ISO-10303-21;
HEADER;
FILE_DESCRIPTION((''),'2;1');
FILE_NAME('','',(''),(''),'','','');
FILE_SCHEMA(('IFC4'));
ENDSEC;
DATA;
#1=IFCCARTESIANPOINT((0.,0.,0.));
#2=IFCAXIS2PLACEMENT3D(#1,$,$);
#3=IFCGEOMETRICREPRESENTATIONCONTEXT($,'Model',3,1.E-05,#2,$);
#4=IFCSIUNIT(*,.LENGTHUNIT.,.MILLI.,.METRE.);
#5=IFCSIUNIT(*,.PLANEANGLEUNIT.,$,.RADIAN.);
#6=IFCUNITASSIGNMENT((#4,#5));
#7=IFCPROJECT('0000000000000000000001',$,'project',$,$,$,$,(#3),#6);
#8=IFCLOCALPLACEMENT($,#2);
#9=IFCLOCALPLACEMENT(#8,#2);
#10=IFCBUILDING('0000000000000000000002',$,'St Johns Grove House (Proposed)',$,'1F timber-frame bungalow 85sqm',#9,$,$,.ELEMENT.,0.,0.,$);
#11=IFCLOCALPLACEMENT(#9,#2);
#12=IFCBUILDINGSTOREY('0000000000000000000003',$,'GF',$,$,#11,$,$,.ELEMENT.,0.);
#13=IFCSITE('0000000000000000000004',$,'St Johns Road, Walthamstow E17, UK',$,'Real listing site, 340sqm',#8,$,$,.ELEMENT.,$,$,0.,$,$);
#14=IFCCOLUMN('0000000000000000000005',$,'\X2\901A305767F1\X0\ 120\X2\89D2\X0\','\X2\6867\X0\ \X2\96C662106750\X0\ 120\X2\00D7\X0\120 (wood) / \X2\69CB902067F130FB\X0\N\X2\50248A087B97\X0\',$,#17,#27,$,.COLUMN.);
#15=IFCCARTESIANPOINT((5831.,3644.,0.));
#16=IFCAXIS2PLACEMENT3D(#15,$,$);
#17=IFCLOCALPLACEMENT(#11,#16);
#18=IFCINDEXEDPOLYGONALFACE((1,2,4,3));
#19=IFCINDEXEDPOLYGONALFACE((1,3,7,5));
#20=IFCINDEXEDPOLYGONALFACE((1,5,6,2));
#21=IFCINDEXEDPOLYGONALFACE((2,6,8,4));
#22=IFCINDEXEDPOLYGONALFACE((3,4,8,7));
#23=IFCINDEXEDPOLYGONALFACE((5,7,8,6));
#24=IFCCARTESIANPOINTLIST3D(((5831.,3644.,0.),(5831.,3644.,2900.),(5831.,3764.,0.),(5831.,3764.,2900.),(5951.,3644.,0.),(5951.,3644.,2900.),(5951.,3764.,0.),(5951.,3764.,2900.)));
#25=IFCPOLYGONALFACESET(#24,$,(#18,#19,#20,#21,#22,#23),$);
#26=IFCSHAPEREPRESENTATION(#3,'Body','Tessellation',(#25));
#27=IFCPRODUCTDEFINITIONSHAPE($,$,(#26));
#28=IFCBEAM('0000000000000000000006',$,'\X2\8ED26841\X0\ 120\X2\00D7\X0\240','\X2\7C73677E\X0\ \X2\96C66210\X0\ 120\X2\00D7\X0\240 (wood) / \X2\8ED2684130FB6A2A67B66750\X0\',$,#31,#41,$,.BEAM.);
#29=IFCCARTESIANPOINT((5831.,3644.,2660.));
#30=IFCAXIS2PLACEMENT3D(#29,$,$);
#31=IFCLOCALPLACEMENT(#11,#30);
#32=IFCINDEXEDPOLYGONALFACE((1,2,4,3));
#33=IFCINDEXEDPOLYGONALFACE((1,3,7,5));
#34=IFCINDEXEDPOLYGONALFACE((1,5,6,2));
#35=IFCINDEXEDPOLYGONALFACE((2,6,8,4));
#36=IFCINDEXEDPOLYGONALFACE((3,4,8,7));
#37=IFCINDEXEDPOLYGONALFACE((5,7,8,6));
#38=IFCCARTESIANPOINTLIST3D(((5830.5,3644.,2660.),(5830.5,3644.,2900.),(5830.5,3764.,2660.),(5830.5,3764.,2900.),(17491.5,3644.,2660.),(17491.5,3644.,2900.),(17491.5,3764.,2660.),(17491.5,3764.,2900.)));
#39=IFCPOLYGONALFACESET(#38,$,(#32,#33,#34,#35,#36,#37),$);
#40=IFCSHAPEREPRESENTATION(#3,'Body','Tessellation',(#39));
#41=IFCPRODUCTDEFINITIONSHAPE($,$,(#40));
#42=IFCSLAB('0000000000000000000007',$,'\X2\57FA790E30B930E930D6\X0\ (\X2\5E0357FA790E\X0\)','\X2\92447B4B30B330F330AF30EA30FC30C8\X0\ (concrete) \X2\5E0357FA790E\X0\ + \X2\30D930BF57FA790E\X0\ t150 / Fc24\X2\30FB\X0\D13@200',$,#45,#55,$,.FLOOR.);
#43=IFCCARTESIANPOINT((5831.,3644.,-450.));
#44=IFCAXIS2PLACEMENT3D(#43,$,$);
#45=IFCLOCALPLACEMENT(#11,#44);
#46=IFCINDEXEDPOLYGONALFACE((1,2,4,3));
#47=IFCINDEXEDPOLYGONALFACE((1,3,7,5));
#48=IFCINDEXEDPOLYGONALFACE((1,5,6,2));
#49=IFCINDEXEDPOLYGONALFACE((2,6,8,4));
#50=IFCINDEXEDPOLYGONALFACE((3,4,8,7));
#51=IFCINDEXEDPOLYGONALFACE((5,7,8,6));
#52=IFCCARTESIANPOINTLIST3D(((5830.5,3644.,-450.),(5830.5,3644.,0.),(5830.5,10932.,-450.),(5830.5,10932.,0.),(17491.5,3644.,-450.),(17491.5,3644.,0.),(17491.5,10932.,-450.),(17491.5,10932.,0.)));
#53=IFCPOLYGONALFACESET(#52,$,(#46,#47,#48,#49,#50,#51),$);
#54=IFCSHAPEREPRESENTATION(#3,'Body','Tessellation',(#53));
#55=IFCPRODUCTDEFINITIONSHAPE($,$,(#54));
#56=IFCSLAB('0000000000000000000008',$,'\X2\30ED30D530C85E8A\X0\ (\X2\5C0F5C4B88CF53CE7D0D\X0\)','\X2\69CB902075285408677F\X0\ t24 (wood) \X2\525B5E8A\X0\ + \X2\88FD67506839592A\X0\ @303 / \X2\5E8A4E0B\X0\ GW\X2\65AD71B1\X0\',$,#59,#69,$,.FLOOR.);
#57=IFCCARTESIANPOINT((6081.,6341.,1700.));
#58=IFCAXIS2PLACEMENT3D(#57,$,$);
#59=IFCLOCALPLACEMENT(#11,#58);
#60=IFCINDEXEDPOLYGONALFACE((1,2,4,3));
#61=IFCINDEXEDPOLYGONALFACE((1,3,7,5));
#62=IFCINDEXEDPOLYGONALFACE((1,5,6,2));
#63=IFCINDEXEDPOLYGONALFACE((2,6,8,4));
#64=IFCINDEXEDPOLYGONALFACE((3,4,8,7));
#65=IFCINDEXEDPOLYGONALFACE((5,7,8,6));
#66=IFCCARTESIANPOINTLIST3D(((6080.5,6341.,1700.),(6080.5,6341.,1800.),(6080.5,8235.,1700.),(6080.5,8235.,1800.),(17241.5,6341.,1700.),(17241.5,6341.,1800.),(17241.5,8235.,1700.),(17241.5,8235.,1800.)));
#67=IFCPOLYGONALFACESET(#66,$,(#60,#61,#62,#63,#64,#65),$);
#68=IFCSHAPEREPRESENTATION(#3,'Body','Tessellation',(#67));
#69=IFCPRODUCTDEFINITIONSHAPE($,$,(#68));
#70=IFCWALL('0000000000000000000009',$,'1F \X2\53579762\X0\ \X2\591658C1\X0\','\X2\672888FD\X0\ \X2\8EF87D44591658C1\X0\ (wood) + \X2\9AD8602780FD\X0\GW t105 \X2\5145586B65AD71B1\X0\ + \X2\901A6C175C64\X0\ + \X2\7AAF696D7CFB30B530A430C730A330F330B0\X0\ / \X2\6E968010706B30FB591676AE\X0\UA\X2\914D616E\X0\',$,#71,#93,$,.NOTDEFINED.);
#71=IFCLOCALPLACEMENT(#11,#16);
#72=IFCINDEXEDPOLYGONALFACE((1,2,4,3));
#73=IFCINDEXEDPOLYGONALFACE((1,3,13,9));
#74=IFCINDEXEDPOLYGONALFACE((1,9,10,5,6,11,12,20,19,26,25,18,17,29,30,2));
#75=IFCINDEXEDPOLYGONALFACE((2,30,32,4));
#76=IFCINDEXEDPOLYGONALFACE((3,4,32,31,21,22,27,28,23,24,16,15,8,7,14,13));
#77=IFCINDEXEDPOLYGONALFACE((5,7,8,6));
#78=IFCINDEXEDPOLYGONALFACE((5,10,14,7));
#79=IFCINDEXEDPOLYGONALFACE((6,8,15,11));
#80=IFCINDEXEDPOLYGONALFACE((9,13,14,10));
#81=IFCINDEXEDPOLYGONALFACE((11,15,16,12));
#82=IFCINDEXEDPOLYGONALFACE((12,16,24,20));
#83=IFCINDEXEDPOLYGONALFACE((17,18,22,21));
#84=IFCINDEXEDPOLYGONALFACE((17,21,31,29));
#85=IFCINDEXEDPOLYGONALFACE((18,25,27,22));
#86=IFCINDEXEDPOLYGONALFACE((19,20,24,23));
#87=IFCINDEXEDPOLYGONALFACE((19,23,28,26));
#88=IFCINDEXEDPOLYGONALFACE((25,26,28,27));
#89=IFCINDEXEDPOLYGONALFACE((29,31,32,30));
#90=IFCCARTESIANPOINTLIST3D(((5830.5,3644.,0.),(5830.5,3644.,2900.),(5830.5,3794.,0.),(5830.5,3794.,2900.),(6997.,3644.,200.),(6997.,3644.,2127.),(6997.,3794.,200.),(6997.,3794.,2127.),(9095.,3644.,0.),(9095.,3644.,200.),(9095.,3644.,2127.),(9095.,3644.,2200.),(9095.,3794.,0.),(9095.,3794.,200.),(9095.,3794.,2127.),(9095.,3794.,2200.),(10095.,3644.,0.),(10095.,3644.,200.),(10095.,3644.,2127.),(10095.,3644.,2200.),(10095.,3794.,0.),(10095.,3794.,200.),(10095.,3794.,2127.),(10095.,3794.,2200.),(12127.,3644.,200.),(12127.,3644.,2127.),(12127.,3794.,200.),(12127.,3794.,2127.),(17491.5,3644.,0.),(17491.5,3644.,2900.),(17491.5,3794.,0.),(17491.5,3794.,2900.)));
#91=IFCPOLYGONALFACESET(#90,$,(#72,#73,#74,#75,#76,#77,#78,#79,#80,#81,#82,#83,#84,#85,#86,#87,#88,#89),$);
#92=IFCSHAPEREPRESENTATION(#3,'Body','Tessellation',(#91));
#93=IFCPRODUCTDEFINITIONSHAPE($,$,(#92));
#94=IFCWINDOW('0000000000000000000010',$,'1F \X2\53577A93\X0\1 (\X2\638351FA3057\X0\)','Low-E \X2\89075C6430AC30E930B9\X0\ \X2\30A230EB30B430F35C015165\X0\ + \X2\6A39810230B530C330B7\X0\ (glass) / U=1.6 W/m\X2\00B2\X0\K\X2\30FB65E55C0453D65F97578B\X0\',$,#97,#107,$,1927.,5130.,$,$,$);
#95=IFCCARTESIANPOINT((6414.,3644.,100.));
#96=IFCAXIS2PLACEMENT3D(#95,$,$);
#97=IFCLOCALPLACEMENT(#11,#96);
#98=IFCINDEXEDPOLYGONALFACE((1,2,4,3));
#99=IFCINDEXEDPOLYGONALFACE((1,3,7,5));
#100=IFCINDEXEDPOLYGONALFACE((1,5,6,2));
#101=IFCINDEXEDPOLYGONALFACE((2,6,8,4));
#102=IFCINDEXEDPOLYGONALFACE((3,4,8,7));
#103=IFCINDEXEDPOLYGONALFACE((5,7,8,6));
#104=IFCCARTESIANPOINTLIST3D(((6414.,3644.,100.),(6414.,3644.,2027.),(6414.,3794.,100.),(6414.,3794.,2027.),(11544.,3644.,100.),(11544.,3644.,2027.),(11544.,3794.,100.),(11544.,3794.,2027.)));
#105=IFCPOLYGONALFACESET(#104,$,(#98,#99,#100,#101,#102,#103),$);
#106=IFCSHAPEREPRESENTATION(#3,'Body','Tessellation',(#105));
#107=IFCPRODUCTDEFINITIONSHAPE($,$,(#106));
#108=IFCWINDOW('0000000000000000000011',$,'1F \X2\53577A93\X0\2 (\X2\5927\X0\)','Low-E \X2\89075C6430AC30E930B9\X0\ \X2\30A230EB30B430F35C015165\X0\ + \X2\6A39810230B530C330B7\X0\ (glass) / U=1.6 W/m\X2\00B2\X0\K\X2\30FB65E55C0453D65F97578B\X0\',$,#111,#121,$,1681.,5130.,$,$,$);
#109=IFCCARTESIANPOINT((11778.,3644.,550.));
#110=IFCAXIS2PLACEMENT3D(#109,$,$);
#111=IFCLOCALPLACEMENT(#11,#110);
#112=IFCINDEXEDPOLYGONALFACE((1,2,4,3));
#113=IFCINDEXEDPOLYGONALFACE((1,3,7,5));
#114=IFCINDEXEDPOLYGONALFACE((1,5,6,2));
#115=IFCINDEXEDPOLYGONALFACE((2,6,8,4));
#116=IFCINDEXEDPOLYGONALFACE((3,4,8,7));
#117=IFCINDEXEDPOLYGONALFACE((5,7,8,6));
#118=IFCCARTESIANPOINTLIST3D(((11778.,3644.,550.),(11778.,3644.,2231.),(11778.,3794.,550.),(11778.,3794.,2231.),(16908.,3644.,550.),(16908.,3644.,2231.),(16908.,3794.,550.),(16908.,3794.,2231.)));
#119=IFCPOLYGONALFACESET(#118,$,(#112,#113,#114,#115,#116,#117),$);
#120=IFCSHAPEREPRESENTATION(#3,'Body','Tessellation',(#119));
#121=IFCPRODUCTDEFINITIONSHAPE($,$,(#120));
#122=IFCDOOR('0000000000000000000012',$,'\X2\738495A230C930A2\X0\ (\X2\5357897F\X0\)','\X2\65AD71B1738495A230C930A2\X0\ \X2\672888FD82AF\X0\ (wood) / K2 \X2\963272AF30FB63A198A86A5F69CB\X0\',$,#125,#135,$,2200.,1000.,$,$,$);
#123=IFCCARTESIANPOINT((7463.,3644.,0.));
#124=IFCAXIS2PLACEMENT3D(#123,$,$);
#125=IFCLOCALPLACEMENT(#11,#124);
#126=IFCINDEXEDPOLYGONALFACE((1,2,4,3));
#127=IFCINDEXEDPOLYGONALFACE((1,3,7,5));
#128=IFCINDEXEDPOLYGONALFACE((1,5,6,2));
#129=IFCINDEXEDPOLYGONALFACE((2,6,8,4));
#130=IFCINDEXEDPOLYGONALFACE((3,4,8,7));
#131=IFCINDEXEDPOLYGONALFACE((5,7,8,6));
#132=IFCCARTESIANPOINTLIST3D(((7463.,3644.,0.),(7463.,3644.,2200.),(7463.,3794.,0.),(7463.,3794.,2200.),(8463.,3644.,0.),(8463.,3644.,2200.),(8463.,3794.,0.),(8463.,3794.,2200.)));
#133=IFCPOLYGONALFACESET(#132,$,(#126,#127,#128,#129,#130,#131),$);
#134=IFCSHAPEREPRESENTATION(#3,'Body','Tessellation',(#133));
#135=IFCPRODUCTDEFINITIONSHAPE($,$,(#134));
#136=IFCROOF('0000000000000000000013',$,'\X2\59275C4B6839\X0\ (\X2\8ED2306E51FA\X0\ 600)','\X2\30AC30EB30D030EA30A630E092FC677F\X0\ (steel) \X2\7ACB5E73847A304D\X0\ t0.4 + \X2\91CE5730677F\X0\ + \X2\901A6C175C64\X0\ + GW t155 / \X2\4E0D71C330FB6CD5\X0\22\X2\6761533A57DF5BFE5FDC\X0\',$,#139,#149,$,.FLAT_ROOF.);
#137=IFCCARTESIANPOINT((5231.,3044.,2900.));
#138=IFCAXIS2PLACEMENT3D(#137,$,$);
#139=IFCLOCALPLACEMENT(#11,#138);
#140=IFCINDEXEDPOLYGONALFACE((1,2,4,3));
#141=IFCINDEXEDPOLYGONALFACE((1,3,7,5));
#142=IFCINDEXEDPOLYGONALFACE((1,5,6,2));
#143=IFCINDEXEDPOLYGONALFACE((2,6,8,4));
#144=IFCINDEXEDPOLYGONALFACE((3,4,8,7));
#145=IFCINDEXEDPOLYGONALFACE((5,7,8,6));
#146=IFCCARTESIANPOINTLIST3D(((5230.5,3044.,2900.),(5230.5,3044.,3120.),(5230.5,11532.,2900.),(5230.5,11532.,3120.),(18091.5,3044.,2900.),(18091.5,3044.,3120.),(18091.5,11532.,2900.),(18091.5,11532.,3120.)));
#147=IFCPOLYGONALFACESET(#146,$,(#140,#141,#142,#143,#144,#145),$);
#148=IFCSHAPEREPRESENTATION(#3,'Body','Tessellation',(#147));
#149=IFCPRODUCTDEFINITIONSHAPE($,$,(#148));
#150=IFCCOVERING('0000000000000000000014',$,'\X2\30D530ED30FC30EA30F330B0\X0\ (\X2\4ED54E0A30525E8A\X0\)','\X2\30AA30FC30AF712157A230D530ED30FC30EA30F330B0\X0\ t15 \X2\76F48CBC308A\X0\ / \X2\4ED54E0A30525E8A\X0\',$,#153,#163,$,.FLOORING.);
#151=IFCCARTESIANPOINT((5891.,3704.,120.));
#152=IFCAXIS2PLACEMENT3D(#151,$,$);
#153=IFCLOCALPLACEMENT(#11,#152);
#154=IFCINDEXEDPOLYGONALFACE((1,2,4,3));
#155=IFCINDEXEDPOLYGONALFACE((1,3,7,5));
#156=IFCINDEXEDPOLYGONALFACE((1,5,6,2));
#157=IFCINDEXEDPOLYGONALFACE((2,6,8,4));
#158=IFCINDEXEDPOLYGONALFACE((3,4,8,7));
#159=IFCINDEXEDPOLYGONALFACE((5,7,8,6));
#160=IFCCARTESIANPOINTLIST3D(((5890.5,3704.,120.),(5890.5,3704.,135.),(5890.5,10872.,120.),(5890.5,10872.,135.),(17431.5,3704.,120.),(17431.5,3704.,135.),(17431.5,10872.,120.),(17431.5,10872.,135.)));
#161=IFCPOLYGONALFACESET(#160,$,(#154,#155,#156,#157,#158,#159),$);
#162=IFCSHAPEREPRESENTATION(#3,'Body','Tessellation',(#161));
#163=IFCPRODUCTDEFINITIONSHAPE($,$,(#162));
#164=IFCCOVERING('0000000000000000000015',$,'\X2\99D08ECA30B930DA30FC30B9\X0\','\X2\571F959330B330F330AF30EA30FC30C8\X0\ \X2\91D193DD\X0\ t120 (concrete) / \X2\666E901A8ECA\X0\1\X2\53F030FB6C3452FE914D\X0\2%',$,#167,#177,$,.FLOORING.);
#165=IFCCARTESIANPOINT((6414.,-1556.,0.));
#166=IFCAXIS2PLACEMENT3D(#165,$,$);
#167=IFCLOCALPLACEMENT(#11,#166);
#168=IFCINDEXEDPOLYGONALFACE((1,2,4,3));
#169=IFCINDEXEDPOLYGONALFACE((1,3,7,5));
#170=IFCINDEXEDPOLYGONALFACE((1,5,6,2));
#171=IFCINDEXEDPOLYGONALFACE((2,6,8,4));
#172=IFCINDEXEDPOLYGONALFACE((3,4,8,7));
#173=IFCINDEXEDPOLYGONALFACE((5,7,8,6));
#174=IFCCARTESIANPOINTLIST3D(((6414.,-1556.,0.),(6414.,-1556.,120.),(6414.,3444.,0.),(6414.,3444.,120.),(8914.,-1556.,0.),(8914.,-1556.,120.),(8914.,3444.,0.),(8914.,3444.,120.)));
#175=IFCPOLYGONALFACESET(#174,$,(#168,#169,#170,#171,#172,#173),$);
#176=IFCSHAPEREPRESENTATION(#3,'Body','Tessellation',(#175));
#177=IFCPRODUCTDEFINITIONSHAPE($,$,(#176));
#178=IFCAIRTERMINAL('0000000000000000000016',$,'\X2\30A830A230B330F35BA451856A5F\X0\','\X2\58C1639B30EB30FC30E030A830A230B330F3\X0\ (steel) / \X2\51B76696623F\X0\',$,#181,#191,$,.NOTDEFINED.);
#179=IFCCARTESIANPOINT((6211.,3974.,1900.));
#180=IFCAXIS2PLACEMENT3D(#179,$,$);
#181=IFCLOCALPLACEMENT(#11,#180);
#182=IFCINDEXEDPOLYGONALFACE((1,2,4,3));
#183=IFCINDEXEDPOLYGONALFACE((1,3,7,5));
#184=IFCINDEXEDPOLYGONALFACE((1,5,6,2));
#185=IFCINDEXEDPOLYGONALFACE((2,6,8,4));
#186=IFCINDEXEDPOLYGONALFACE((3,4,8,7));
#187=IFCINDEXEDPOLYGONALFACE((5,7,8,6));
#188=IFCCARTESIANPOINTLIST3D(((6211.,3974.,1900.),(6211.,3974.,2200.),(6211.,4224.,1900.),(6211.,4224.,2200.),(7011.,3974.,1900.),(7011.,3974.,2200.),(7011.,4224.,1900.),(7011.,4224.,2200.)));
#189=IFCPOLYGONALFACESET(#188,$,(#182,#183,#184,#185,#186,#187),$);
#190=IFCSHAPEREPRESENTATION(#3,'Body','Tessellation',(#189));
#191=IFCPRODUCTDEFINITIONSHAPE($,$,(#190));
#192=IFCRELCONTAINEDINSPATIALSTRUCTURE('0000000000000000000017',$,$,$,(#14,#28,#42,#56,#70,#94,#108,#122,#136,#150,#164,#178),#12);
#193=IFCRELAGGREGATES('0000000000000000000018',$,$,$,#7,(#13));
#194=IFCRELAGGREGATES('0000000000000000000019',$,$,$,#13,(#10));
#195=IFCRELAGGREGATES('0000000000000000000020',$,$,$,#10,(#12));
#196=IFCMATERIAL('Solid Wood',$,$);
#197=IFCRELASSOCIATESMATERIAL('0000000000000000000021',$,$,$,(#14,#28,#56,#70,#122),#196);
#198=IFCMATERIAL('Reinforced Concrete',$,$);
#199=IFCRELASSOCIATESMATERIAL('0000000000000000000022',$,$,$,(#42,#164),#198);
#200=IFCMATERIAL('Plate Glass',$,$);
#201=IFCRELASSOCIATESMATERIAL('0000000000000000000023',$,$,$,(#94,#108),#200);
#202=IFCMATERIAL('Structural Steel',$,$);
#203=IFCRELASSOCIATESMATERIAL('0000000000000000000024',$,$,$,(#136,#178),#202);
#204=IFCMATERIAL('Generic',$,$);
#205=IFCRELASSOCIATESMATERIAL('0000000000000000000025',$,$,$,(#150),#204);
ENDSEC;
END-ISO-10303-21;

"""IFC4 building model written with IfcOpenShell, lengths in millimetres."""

from ifc_helpers import new_model, si_unit, frame, frame_2d, origin, place, context, project, spatial, rectangle, extrude, material, element, fill, save


model = new_model("IFC4")

# Units and contexts
model_context = context("Model", 3, precision=1e-05, world=origin())
ifc_project = project(units=[si_unit("LENGTHUNIT", "METRE", prefix="MILLI"), si_unit("PLANEANGLEUNIT", "RADIAN")], contexts=[model_context])

# Site, building, storey
site_placement = place(None, origin())
site = spatial("IfcSite", under=ifc_project, at=site_placement, Name="St Johns Road, Walthamstow E17, UK", ObjectType="Real listing site, 340sqm", CompositionType="ELEMENT", RefElevation=0.0)
building_placement = place(site_placement, origin())
building = spatial("IfcBuilding", under=site, at=building_placement, Name="St Johns Grove House (Proposed)", ObjectType="1F timber-frame bungalow 85sqm", CompositionType="ELEMENT", ElevationOfRefHeight=0.0, ElevationOfTerrain=0.0)
storey_placement = place(building_placement, origin())
storey = spatial("IfcBuildingStorey", under=building, at=storey_placement, Name="GF", CompositionType="ELEMENT", Elevation=0.0)

# Column
ifc_material_1 = material(Name="Solid Wood")
column_1_placement = place(storey_placement, frame((5831.0, 3644.0, 0.0)))
element("IfcColumn", 1, at=column_1_placement, inside=storey, material=ifc_material_1, Name="通し柱 120角", Description="桧 集成材 120×120 (wood) / 構造柱・N値計算", PredefinedType="COLUMN", context=model_context, shape_type="SweptSolid", body=[
    extrude(rectangle(XDim=120.0, YDim=120.0, at=frame_2d((60.0, 60.0))), frame((5831.0, 3644.0, 0.0)), (0.0, 0.0, 1.0), 2900.0),
])

# Beam
beam_1_placement = place(storey_placement, frame((5831.0, 3644.0, 2660.0)))
element("IfcBeam", 2, at=beam_1_placement, inside=storey, material=ifc_material_1, Name="軒桁 120×240", Description="米松 集成 120×240 (wood) / 軒桁・横架材", PredefinedType="BEAM", context=model_context, shape_type="SweptSolid", body=[
    extrude(rectangle(XDim=11661.0, YDim=120.0, at=frame_2d((5830.0, 60.0))), frame((5831.0, 3644.0, 2660.0)), (0.0, 0.0, 1.0), 240.0),
])

# Slabs
ifc_material_2 = material(Name="Reinforced Concrete")
slab_1_placement = place(storey_placement, frame((5831.0, 3644.0, -450.0)))
element("IfcSlab", 3, at=slab_1_placement, inside=storey, material=ifc_material_2, Name="基礎スラブ (布基礎)", Description="鉄筋コンクリート (concrete) 布基礎 + ベタ基礎 t150 / Fc24・D13@200", PredefinedType="FLOOR", context=model_context, shape_type="SweptSolid", body=[
    extrude(rectangle(XDim=11661.0, YDim=7288.0, at=frame_2d((5830.0, 3644.0))), frame((5831.0, 3644.0, -450.0)), (0.0, 0.0, 1.0), 450.0),
])
slab_2_placement = place(storey_placement, frame((6081.0, 6341.0, 1700.0)))
element("IfcSlab", 4, at=slab_2_placement, inside=storey, material=ifc_material_1, Name="ロフト床 (小屋裏収納)", Description="構造用合板 t24 (wood) 剛床 + 製材根太 @303 / 床下 GW断熱", PredefinedType="FLOOR", context=model_context, shape_type="SweptSolid", body=[
    extrude(rectangle(XDim=11161.0, YDim=1894.0, at=frame_2d((5580.0, 947.0))), frame((6081.0, 6341.0, 1700.0)), (0.0, 0.0, 1.0), 100.0),
])

# Wall, openings, windows, door
wall_1_placement = place(storey_placement, frame((5831.0, 3644.0, 0.0)))
wall_1 = element("IfcWall", 5, at=wall_1_placement, inside=storey, material=ifc_material_1, Name="1F 南面 外壁", Description="木製 軸組外壁 (wood) + 高性能GW t105 充填断熱 + 通気層 + 窯業系サイディング / 準耐火・外皮UA配慮", PredefinedType="NOTDEFINED", context=model_context, shape_type="SweptSolid", body=[
    extrude(rectangle(XDim=11661.0, YDim=150.0, at=frame_2d((5830.0, 75.0))), frame((5831.0, 3644.0, 0.0)), (0.0, 0.0, 1.0), 2900.0),
])
opening_1_placement = place(storey_placement, frame((6414.0, 3644.0, 100.0)))
opening_1 = element("IfcOpeningElement", 6, at=opening_1_placement, cuts=wall_1, PredefinedType="NOTDEFINED", context=model_context, shape_type="SweptSolid", body=[
    extrude(rectangle(XDim=5130.0, YDim=150.0, at=frame_2d((2565.0, 75.0))), frame((6414.0, 3644.0, 100.0)), (0.0, 0.0, 1.0), 1927.0),
])
opening_2_placement = place(storey_placement, frame((11778.0, 3644.0, 550.0)))
opening_2 = element("IfcOpeningElement", 7, at=opening_2_placement, cuts=wall_1, PredefinedType="NOTDEFINED", context=model_context, shape_type="SweptSolid", body=[
    extrude(rectangle(XDim=5130.0, YDim=150.0, at=frame_2d((2565.0, 75.0))), frame((11778.0, 3644.0, 550.0)), (0.0, 0.0, 1.0), 1681.0),
])
opening_3_placement = place(storey_placement, frame((7463.0, 3644.0, 0.0)))
opening_3 = element("IfcOpeningElement", 8, at=opening_3_placement, cuts=wall_1, PredefinedType="NOTDEFINED", context=model_context, shape_type="SweptSolid", body=[
    extrude(rectangle(XDim=1000.0, YDim=150.0, at=frame_2d((500.0, 75.0))), frame((7463.0, 3644.0, 0.0)), (0.0, 0.0, 1.0), 2200.0),
])
ifc_material_3 = material(Name="Plate Glass")
window_1_placement = place(storey_placement, frame((6414.0, 3644.0, 100.0)))
window_1 = element("IfcWindow", 9, at=window_1_placement, inside=storey, material=ifc_material_3, Name="1F 南窓1 (掃出し)", Description="Low-E 複層ガラス アルゴン封入 + 樹脂サッシ (glass) / U=1.6 W/m²K・日射取得型", OverallHeight=1927.0, OverallWidth=5130.0, context=model_context, shape_type="SweptSolid", body=[
    extrude(rectangle(XDim=5130.0, YDim=150.0, at=frame_2d((2565.0, 75.0))), frame((6414.0, 3644.0, 100.0)), (0.0, 0.0, 1.0), 1927.0),
])
fill(opening_1, window_1)
window_2_placement = place(storey_placement, frame((11778.0, 3644.0, 550.0)))
window_2 = element("IfcWindow", 10, at=window_2_placement, inside=storey, material=ifc_material_3, Name="1F 南窓2 (大)", Description="Low-E 複層ガラス アルゴン封入 + 樹脂サッシ (glass) / U=1.6 W/m²K・日射取得型", OverallHeight=1681.0, OverallWidth=5130.0, context=model_context, shape_type="SweptSolid", body=[
    extrude(rectangle(XDim=5130.0, YDim=150.0, at=frame_2d((2565.0, 75.0))), frame((11778.0, 3644.0, 550.0)), (0.0, 0.0, 1.0), 1681.0),
])
fill(opening_2, window_2)
door_placement = place(storey_placement, frame((7463.0, 3644.0, 0.0)))
door = element("IfcDoor", 11, at=door_placement, inside=storey, material=ifc_material_1, Name="玄関ドア (南西)", Description="断熱玄関ドア 木製芯 (wood) / K2 防犯・採風機構", OverallHeight=2200.0, OverallWidth=1000.0, context=model_context, shape_type="SweptSolid", body=[
    extrude(rectangle(XDim=1000.0, YDim=150.0, at=frame_2d((500.0, 75.0))), frame((7463.0, 3644.0, 0.0)), (0.0, 0.0, 1.0), 2200.0),
])
fill(opening_3, door)

# Roof
ifc_material_4 = material(Name="Structural Steel")
roof_placement = place(storey_placement, frame((5231.0, 3044.0, 2900.0)))
element("IfcRoof", 12, at=roof_placement, inside=storey, material=ifc_material_4, Name="大屋根 (軒の出 600)", Description="ガルバリウム鋼板 (steel) 立平葺き t0.4 + 野地板 + 通気層 + GW t155 / 不燃・法22条区域対応", PredefinedType="FLAT_ROOF", context=model_context, shape_type="SweptSolid", body=[
    extrude(rectangle(XDim=12861.0, YDim=8488.0, at=frame_2d((6430.0, 4244.0))), frame((5231.0, 3044.0, 2900.0)), (0.0, 0.0, 1.0), 220.0),
])

# Coverings
ifc_material_5 = material(Name="Generic")
covering_1_placement = place(storey_placement, frame((5891.0, 3704.0, 120.0)))
element("IfcCovering", 13, at=covering_1_placement, inside=storey, material=ifc_material_5, Name="フローリング (仕上げ床)", Description="オーク無垢フローリング t15 直貼り / 仕上げ床", PredefinedType="FLOORING", context=model_context, shape_type="SweptSolid", body=[
    extrude(rectangle(XDim=11541.0, YDim=7168.0, at=frame_2d((5770.0, 3584.0))), frame((5891.0, 3704.0, 120.0)), (0.0, 0.0, 1.0), 15.0),
])
covering_2_placement = place(storey_placement, frame((6414.0, -1556.0, 0.0)))
element("IfcCovering", 14, at=covering_2_placement, inside=storey, material=ifc_material_2, Name="駐車スペース", Description="土間コンクリート 金鏝 t120 (concrete) / 普通車1台・水勾配2%", PredefinedType="FLOORING", context=model_context, shape_type="SweptSolid", body=[
    extrude(rectangle(XDim=2500.0, YDim=5000.0, at=frame_2d((1250.0, 2500.0))), frame((6414.0, -1556.0, 0.0)), (0.0, 0.0, 1.0), 120.0),
])

# Air terminal
air_terminal_placement = place(storey_placement, frame((6211.0, 3974.0, 1900.0)))
element("IfcAirTerminal", 15, at=air_terminal_placement, inside=storey, material=ifc_material_4, Name="エアコン室内機", Description="壁掛ルームエアコン (steel) / 冷暖房", PredefinedType="NOTDEFINED", context=model_context, shape_type="SweptSolid", body=[
    extrude(rectangle(XDim=800.0, YDim=250.0, at=frame_2d((400.0, 125.0))), frame((6211.0, 3974.0, 1900.0)), (0.0, 0.0, 1.0), 300.0),
])

save(model, "model.ifc")
